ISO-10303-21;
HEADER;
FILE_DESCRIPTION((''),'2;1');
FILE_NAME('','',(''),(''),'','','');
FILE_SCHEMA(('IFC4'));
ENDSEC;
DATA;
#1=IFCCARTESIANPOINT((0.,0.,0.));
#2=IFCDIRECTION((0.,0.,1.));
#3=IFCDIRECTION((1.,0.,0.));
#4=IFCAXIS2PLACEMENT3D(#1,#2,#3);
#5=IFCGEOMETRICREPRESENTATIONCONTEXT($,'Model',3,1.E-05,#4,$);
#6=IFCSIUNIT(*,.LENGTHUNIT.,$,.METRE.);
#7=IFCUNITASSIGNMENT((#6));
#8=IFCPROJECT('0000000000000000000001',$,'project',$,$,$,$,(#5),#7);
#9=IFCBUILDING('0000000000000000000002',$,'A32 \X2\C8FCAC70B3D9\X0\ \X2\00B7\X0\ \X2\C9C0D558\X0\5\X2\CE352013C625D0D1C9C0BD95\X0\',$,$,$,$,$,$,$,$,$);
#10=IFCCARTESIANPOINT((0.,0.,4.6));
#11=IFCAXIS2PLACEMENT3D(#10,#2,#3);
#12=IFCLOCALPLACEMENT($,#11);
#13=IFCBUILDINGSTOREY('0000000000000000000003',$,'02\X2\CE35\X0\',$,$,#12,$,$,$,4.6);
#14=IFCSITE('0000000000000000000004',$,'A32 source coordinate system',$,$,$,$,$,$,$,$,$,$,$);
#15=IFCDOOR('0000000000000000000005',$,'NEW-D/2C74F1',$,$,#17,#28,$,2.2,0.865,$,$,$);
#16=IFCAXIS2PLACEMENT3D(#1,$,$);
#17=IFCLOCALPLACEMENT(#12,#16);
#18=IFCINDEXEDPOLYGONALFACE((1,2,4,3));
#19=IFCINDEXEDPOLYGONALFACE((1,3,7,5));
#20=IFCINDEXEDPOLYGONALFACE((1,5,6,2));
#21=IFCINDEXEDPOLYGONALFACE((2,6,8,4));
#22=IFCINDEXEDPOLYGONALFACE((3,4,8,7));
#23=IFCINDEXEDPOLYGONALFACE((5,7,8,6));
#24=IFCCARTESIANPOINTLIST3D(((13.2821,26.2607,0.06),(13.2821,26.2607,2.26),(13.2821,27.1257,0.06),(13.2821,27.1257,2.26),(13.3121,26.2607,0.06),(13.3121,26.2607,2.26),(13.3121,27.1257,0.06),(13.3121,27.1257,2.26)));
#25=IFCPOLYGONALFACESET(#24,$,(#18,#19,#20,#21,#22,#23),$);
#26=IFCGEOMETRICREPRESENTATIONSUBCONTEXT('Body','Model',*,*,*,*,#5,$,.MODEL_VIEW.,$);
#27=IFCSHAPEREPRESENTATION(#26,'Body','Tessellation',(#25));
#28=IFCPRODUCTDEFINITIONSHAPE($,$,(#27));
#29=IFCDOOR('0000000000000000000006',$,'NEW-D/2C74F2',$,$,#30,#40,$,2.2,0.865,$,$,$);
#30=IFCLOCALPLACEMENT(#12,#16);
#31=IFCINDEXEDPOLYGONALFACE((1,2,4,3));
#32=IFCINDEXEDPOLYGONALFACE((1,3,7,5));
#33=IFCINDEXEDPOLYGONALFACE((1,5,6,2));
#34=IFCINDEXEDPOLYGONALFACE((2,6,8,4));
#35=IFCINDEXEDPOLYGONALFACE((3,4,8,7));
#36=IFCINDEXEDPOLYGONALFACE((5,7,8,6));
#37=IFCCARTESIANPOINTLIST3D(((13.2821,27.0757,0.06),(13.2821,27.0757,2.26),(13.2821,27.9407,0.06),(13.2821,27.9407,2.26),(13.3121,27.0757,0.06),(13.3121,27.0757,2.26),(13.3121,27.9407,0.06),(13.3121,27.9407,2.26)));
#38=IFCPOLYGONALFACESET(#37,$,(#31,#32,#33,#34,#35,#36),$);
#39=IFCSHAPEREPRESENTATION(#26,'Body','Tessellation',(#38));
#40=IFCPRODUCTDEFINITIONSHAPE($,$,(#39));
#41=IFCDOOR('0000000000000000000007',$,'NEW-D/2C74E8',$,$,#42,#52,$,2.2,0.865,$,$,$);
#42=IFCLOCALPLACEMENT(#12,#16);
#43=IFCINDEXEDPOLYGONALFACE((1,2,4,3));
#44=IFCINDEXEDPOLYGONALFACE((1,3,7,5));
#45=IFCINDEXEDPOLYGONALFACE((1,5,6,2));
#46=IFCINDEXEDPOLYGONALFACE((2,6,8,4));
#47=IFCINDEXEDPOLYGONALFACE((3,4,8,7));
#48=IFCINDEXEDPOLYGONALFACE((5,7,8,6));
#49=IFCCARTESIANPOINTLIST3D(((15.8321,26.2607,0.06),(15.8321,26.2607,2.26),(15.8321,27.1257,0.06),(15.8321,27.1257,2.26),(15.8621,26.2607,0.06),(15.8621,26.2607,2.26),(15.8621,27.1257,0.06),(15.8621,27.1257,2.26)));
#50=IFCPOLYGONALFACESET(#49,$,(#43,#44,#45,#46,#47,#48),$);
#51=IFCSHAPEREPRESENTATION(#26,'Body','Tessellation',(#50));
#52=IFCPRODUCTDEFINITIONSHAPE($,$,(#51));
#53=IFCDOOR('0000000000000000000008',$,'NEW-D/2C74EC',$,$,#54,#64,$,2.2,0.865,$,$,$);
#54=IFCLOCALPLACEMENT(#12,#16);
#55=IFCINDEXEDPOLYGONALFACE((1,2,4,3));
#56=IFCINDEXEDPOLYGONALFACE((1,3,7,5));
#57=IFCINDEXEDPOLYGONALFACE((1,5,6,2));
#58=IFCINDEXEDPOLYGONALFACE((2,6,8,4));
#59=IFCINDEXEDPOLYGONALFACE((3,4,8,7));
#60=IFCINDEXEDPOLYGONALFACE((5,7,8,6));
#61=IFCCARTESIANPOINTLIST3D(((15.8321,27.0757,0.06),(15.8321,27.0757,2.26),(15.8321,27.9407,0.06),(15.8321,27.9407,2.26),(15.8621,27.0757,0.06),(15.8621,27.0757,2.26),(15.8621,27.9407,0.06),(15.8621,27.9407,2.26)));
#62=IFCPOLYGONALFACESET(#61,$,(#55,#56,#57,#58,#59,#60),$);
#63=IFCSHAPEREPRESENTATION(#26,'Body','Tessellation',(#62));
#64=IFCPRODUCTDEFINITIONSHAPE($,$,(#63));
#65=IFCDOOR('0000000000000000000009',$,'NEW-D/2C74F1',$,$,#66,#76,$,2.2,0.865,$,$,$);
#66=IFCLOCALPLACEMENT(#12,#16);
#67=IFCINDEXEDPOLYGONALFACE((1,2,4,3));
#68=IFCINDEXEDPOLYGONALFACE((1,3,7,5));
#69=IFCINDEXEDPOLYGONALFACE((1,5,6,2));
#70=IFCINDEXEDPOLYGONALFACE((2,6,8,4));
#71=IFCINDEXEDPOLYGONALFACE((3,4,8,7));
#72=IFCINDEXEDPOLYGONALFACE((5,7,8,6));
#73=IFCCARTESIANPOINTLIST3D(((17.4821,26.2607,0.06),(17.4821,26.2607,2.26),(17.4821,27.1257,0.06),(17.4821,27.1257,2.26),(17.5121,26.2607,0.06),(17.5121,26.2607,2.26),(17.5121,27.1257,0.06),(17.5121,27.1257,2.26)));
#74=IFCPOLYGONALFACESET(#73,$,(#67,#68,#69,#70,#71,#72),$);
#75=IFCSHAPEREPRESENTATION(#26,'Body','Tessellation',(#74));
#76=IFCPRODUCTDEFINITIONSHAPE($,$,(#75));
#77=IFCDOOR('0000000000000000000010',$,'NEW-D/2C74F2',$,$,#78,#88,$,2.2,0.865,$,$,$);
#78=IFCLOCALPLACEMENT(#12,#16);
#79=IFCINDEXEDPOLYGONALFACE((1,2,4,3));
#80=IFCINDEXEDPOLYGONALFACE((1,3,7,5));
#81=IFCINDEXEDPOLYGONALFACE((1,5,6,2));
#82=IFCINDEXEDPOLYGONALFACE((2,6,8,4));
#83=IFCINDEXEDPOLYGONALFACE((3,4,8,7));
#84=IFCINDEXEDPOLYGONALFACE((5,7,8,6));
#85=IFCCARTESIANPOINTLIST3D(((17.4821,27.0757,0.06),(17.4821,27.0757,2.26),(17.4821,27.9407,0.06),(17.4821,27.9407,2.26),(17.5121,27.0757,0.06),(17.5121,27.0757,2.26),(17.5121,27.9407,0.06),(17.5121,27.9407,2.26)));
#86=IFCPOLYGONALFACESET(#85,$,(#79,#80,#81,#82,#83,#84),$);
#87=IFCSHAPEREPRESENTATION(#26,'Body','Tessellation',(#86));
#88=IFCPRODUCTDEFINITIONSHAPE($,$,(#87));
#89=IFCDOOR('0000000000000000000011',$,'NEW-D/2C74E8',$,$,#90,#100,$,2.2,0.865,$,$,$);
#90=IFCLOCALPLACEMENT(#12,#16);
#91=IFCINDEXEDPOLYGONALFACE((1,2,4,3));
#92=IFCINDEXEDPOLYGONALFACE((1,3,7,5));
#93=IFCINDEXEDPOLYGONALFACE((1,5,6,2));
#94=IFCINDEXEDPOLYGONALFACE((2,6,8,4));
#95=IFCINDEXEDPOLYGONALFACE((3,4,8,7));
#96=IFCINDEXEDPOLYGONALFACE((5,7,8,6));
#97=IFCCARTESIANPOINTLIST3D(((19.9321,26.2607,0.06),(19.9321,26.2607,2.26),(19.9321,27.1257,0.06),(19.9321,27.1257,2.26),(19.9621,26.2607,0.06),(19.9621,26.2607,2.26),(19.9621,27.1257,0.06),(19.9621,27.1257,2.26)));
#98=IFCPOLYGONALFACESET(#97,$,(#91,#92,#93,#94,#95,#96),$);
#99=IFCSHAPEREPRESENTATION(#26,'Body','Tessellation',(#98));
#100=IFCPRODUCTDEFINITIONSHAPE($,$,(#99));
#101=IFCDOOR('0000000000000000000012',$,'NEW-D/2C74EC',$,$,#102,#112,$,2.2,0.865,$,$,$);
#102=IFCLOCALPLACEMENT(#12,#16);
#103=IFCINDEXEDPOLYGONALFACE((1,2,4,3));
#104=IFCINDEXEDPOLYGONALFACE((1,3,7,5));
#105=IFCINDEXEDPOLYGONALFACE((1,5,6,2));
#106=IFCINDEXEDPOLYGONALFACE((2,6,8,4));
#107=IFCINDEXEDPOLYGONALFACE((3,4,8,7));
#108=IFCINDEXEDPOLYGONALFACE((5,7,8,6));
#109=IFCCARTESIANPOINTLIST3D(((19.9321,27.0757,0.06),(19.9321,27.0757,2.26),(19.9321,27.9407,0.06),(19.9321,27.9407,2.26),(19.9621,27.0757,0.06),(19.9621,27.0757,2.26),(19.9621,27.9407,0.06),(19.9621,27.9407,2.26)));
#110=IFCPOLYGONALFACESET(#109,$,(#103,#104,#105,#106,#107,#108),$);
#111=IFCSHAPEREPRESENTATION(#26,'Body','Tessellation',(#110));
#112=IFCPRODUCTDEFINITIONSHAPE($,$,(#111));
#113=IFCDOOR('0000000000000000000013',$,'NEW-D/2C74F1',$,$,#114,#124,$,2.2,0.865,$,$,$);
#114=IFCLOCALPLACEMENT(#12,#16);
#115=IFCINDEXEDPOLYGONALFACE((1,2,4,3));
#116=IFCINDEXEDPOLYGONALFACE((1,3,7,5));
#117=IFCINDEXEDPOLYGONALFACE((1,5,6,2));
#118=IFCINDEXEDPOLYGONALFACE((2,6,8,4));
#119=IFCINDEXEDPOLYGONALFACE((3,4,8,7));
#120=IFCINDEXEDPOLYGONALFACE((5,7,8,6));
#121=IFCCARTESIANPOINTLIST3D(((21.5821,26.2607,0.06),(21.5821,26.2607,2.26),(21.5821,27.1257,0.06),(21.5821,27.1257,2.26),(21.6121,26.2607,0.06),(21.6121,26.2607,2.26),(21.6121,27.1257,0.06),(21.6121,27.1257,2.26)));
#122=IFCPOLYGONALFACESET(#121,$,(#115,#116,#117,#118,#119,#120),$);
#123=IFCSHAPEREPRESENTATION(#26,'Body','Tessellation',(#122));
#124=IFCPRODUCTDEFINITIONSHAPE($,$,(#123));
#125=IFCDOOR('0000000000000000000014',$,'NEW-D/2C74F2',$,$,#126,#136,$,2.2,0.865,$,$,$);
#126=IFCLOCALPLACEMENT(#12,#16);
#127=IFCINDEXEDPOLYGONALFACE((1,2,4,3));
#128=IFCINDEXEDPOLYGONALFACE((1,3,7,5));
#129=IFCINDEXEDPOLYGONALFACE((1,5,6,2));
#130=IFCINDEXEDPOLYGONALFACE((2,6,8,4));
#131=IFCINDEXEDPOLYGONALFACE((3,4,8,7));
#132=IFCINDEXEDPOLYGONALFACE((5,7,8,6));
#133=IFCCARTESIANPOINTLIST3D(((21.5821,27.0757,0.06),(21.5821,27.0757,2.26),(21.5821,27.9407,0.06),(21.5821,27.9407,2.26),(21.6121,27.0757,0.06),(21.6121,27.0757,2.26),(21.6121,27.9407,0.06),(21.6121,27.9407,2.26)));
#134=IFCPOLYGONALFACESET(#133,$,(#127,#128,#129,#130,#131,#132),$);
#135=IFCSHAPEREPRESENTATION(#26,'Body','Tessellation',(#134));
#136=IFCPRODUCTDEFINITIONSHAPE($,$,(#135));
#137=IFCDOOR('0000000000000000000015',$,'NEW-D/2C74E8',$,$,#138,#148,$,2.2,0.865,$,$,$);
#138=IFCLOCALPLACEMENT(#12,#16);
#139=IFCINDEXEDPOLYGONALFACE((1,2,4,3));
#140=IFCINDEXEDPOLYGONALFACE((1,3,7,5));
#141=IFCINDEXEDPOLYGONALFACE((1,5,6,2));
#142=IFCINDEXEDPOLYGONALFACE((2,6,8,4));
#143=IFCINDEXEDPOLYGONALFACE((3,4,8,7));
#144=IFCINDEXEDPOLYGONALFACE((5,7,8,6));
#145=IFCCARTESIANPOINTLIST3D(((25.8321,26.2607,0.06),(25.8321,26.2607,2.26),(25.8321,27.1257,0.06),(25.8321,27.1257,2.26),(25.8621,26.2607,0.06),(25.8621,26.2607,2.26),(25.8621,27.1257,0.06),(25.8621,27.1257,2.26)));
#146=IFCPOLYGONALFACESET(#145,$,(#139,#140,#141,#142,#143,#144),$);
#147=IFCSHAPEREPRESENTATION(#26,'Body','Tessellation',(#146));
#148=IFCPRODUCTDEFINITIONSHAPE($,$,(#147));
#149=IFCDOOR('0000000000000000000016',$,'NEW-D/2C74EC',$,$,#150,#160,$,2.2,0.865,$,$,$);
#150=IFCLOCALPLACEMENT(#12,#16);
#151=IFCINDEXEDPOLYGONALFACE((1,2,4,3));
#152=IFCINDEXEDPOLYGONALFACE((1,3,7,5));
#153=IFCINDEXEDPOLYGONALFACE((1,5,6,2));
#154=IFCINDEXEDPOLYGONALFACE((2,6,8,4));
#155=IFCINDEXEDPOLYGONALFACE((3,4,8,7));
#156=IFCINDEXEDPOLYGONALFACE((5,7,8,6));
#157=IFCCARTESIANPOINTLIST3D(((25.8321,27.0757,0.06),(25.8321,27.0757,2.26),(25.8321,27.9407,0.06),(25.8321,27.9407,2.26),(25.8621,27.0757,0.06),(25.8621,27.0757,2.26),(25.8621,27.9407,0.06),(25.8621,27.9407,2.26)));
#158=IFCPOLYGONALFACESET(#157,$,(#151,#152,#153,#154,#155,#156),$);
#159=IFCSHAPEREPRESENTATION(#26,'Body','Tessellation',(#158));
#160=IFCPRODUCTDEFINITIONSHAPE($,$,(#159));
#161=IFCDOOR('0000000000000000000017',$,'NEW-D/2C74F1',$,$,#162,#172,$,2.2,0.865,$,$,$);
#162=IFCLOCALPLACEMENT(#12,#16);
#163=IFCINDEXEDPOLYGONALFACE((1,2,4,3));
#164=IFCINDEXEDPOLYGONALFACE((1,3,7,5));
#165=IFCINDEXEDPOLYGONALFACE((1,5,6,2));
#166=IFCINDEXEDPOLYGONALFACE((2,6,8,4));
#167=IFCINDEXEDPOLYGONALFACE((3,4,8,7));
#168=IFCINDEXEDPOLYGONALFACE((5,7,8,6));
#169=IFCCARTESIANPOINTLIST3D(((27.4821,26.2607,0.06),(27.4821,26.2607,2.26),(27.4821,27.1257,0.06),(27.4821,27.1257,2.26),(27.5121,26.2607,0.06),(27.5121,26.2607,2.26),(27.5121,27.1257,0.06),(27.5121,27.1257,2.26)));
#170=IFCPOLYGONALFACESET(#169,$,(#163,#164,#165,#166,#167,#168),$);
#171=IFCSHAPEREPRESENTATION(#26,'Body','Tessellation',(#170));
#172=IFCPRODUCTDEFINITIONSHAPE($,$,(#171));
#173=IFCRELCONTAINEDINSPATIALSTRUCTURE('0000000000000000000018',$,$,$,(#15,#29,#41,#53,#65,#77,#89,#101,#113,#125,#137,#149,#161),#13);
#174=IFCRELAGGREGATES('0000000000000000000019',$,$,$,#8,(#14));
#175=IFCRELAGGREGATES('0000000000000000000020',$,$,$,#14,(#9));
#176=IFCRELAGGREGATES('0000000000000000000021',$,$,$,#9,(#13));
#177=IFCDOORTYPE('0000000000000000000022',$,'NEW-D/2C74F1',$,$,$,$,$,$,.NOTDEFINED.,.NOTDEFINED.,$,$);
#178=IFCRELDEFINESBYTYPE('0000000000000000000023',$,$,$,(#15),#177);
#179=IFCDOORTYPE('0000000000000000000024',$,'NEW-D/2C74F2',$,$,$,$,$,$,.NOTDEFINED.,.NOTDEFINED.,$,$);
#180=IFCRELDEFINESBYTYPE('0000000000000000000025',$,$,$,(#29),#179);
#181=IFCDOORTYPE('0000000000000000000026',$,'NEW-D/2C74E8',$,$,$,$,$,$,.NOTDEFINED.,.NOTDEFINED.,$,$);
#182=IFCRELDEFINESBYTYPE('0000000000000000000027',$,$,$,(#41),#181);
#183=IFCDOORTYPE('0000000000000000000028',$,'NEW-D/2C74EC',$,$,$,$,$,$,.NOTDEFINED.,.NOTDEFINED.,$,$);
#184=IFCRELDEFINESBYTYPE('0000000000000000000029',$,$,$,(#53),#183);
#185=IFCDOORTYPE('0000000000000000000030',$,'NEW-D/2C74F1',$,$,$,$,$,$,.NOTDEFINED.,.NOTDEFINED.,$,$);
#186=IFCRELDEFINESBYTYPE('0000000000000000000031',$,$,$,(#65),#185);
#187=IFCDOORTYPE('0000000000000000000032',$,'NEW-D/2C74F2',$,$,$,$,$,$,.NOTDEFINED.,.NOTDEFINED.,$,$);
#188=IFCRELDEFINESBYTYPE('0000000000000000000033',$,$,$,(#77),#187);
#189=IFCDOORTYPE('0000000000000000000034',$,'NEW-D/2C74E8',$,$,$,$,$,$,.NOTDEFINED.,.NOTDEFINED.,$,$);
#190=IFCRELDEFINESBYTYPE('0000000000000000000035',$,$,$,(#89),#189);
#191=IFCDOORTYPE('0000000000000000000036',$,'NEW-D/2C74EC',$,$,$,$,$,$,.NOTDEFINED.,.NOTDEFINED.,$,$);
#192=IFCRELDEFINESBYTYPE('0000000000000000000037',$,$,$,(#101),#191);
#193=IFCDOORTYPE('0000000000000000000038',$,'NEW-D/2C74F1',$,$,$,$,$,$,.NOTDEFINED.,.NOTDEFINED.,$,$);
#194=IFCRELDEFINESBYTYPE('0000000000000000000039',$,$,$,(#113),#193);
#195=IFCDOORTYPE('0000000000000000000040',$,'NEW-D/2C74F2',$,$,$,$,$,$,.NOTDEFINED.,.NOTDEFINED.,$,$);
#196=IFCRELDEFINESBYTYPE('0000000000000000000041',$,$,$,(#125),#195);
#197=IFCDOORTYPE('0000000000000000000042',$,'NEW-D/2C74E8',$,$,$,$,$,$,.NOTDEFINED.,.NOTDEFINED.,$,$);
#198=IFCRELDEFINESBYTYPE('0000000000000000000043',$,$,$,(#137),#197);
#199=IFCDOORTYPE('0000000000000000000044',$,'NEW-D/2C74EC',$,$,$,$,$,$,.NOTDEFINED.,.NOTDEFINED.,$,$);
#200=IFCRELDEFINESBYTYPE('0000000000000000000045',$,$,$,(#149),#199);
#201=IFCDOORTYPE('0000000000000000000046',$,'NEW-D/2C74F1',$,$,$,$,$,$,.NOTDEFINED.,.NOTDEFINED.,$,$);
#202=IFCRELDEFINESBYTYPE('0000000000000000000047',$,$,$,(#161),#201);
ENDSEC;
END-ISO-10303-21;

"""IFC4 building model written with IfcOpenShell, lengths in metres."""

from ifc_helpers import new_model, si_unit, frame, origin, origin_with_axes, place, context, subcontext, project, spatial, polyline, outline, extrude, source, transform, mapped, type_object, type_shapes, element, save


model = new_model("IFC4")

# Units and contexts
model_context = context("Model", 3, precision=1e-05, world=origin_with_axes())
body_context = subcontext(model_context, "Body", "Model", "MODEL_VIEW")
ifc_project = project(units=[si_unit("LENGTHUNIT", "METRE")], contexts=[model_context])

# Site, building, storey
site = spatial("IfcSite", under=ifc_project, Name="A32 source coordinate system")
building = spatial("IfcBuilding", under=site, Name="A32 주거동 · 지하5층–옥탑지붕")
storey_placement = place(None, frame((0.0, 0.0, 4.6), z_axis=(0.0, 0.0, 1.0), x_axis=(1.0, 0.0, 0.0)))
storey = spatial("IfcBuildingStorey", under=building, at=storey_placement, Name="02층", Elevation=4.6)

# Doors
door_type_1 = type_object("IfcDoorType", Name="NEW-D/2C74F1", OperationType="NOTDEFINED", PredefinedType="NOTDEFINED")
shared_shape_1 = source(origin(), body_context, "Body", "SweptSolid", [
    extrude(outline(polyline([(13.3121, 26.2607), (13.2821, 26.2607), (13.2821, 27.1257), (13.3121, 27.1257), (13.3121, 26.2607)])), frame((0.0, 0.0, 0.06)), (0.0, 0.0, 1.0), 2.2),
])
type_shapes(door_type_1, [shared_shape_1])
door_1_placement = place(storey_placement, origin_with_axes())
element("IfcDoor", 1, at=door_1_placement, inside=storey, type_object=door_type_1, Name="NEW-D/2C74F1", OverallHeight=2.2, OverallWidth=0.865, context=body_context, shape_type="MappedRepresentation", body=[
    mapped(shared_shape_1, transform((0.0, 0.0, 0.0), scale=1.0)),
])
door_type_2 = type_object("IfcDoorType", Name="NEW-D/2C74F2", OperationType="NOTDEFINED", PredefinedType="NOTDEFINED")
shared_shape_2 = source(origin(), body_context, "Body", "SweptSolid", [
    extrude(outline(polyline([(13.2821, 27.0757), (13.2821, 27.9407), (13.3121, 27.9407), (13.3121, 27.0757), (13.2821, 27.0757)])), frame((0.0, 0.0, 0.06)), (0.0, 0.0, 1.0), 2.2),
])
type_shapes(door_type_2, [shared_shape_2])
door_2_placement = place(storey_placement, origin_with_axes())
element("IfcDoor", 2, at=door_2_placement, inside=storey, type_object=door_type_2, Name="NEW-D/2C74F2", OverallHeight=2.2, OverallWidth=0.865, context=body_context, shape_type="MappedRepresentation", body=[
    mapped(shared_shape_2, transform((0.0, 0.0, 0.0), scale=1.0)),
])
door_type_3 = type_object("IfcDoorType", Name="NEW-D/2C74E8", OperationType="NOTDEFINED", PredefinedType="NOTDEFINED")
shared_shape_3 = source(origin(), body_context, "Body", "SweptSolid", [
    extrude(outline(polyline([(15.8621, 27.1257), (15.8621, 26.2607), (15.8321, 26.2607), (15.8321, 27.1257), (15.8621, 27.1257)])), frame((0.0, 0.0, 0.06)), (0.0, 0.0, 1.0), 2.2),
])
type_shapes(door_type_3, [shared_shape_3])
door_3_placement = place(storey_placement, origin_with_axes())
element("IfcDoor", 3, at=door_3_placement, inside=storey, type_object=door_type_3, Name="NEW-D/2C74E8", OverallHeight=2.2, OverallWidth=0.865, context=body_context, shape_type="MappedRepresentation", body=[
    mapped(shared_shape_3, transform((0.0, 0.0, 0.0), scale=1.0)),
])
door_type_4 = type_object("IfcDoorType", Name="NEW-D/2C74EC", OperationType="NOTDEFINED", PredefinedType="NOTDEFINED")
shared_shape_4 = source(origin(), body_context, "Body", "SweptSolid", [
    extrude(outline(polyline([(15.8321, 27.9407), (15.8621, 27.9407), (15.8621, 27.0757), (15.8321, 27.0757), (15.8321, 27.9407)])), frame((0.0, 0.0, 0.06)), (0.0, 0.0, 1.0), 2.2),
])
type_shapes(door_type_4, [shared_shape_4])
door_4_placement = place(storey_placement, origin_with_axes())
element("IfcDoor", 4, at=door_4_placement, inside=storey, type_object=door_type_4, Name="NEW-D/2C74EC", OverallHeight=2.2, OverallWidth=0.865, context=body_context, shape_type="MappedRepresentation", body=[
    mapped(shared_shape_4, transform((0.0, 0.0, 0.0), scale=1.0)),
])
door_type_5 = type_object("IfcDoorType", Name="NEW-D/2C74F1", OperationType="NOTDEFINED", PredefinedType="NOTDEFINED")
shared_shape_5 = source(origin(), body_context, "Body", "SweptSolid", [
    extrude(outline(polyline([(17.5121, 26.2607), (17.4821, 26.2607), (17.4821, 27.1257), (17.5121, 27.1257), (17.5121, 26.2607)])), frame((0.0, 0.0, 0.06)), (0.0, 0.0, 1.0), 2.2),
])
type_shapes(door_type_5, [shared_shape_5])
door_5_placement = place(storey_placement, origin_with_axes())
element("IfcDoor", 5, at=door_5_placement, inside=storey, type_object=door_type_5, Name="NEW-D/2C74F1", OverallHeight=2.2, OverallWidth=0.865, context=body_context, shape_type="MappedRepresentation", body=[
    mapped(shared_shape_5, transform((0.0, 0.0, 0.0), scale=1.0)),
])
door_type_6 = type_object("IfcDoorType", Name="NEW-D/2C74F2", OperationType="NOTDEFINED", PredefinedType="NOTDEFINED")
shared_shape_6 = source(origin(), body_context, "Body", "SweptSolid", [
    extrude(outline(polyline([(17.4821, 27.0757), (17.4821, 27.9407), (17.5121, 27.9407), (17.5121, 27.0757), (17.4821, 27.0757)])), frame((0.0, 0.0, 0.06)), (0.0, 0.0, 1.0), 2.2),
])
type_shapes(door_type_6, [shared_shape_6])
door_6_placement = place(storey_placement, origin_with_axes())
element("IfcDoor", 6, at=door_6_placement, inside=storey, type_object=door_type_6, Name="NEW-D/2C74F2", OverallHeight=2.2, OverallWidth=0.865, context=body_context, shape_type="MappedRepresentation", body=[
    mapped(shared_shape_6, transform((0.0, 0.0, 0.0), scale=1.0)),
])
door_type_7 = type_object("IfcDoorType", Name="NEW-D/2C74E8", OperationType="NOTDEFINED", PredefinedType="NOTDEFINED")
shared_shape_7 = source(origin(), body_context, "Body", "SweptSolid", [
    extrude(outline(polyline([(19.9621, 27.1257), (19.9621, 26.2607), (19.9321, 26.2607), (19.9321, 27.1257), (19.9621, 27.1257)])), frame((0.0, 0.0, 0.06)), (0.0, 0.0, 1.0), 2.2),
])
type_shapes(door_type_7, [shared_shape_7])
door_7_placement = place(storey_placement, origin_with_axes())
element("IfcDoor", 7, at=door_7_placement, inside=storey, type_object=door_type_7, Name="NEW-D/2C74E8", OverallHeight=2.2, OverallWidth=0.865, context=body_context, shape_type="MappedRepresentation", body=[
    mapped(shared_shape_7, transform((0.0, 0.0, 0.0), scale=1.0)),
])
door_type_8 = type_object("IfcDoorType", Name="NEW-D/2C74EC", OperationType="NOTDEFINED", PredefinedType="NOTDEFINED")
shared_shape_8 = source(origin(), body_context, "Body", "SweptSolid", [
    extrude(outline(polyline([(19.9321, 27.9407), (19.9621, 27.9407), (19.9621, 27.0757), (19.9321, 27.0757), (19.9321, 27.9407)])), frame((0.0, 0.0, 0.06)), (0.0, 0.0, 1.0), 2.2),
])
type_shapes(door_type_8, [shared_shape_8])
door_8_placement = place(storey_placement, origin_with_axes())
element("IfcDoor", 8, at=door_8_placement, inside=storey, type_object=door_type_8, Name="NEW-D/2C74EC", OverallHeight=2.2, OverallWidth=0.865, context=body_context, shape_type="MappedRepresentation", body=[
    mapped(shared_shape_8, transform((0.0, 0.0, 0.0), scale=1.0)),
])
door_type_9 = type_object("IfcDoorType", Name="NEW-D/2C74F1", OperationType="NOTDEFINED", PredefinedType="NOTDEFINED")
shared_shape_9 = source(origin(), body_context, "Body", "SweptSolid", [
    extrude(outline(polyline([(21.6121, 26.2607), (21.5821, 26.2607), (21.5821, 27.1257), (21.6121, 27.1257), (21.6121, 26.2607)])), frame((0.0, 0.0, 0.06)), (0.0, 0.0, 1.0), 2.2),
])
type_shapes(door_type_9, [shared_shape_9])
door_9_placement = place(storey_placement, origin_with_axes())
element("IfcDoor", 9, at=door_9_placement, inside=storey, type_object=door_type_9, Name="NEW-D/2C74F1", OverallHeight=2.2, OverallWidth=0.865, context=body_context, shape_type="MappedRepresentation", body=[
    mapped(shared_shape_9, transform((0.0, 0.0, 0.0), scale=1.0)),
])
door_type_10 = type_object("IfcDoorType", Name="NEW-D/2C74F2", OperationType="NOTDEFINED", PredefinedType="NOTDEFINED")
shared_shape_10 = source(origin(), body_context, "Body", "SweptSolid", [
    extrude(outline(polyline([(21.5821, 27.0757), (21.5821, 27.9407), (21.6121, 27.9407), (21.6121, 27.0757), (21.5821, 27.0757)])), frame((0.0, 0.0, 0.06)), (0.0, 0.0, 1.0), 2.2),
])
type_shapes(door_type_10, [shared_shape_10])
door_10_placement = place(storey_placement, origin_with_axes())
element("IfcDoor", 10, at=door_10_placement, inside=storey, type_object=door_type_10, Name="NEW-D/2C74F2", OverallHeight=2.2, OverallWidth=0.865, context=body_context, shape_type="MappedRepresentation", body=[
    mapped(shared_shape_10, transform((0.0, 0.0, 0.0), scale=1.0)),
])
door_type_11 = type_object("IfcDoorType", Name="NEW-D/2C74E8", OperationType="NOTDEFINED", PredefinedType="NOTDEFINED")
shared_shape_11 = source(origin(), body_context, "Body", "SweptSolid", [
    extrude(outline(polyline([(25.8621, 27.1257), (25.8621, 26.2607), (25.8321, 26.2607), (25.8321, 27.1257), (25.8621, 27.1257)])), frame((0.0, 0.0, 0.06)), (0.0, 0.0, 1.0), 2.2),
])
type_shapes(door_type_11, [shared_shape_11])
door_11_placement = place(storey_placement, origin_with_axes())
element("IfcDoor", 11, at=door_11_placement, inside=storey, type_object=door_type_11, Name="NEW-D/2C74E8", OverallHeight=2.2, OverallWidth=0.865, context=body_context, shape_type="MappedRepresentation", body=[
    mapped(shared_shape_11, transform((0.0, 0.0, 0.0), scale=1.0)),
])
door_type_12 = type_object("IfcDoorType", Name="NEW-D/2C74EC", OperationType="NOTDEFINED", PredefinedType="NOTDEFINED")
shared_shape_12 = source(origin(), body_context, "Body", "SweptSolid", [
    extrude(outline(polyline([(25.8321, 27.9407), (25.8621, 27.9407), (25.8621, 27.0757), (25.8321, 27.0757), (25.8321, 27.9407)])), frame((0.0, 0.0, 0.06)), (0.0, 0.0, 1.0), 2.2),
])
type_shapes(door_type_12, [shared_shape_12])
door_12_placement = place(storey_placement, origin_with_axes())
element("IfcDoor", 12, at=door_12_placement, inside=storey, type_object=door_type_12, Name="NEW-D/2C74EC", OverallHeight=2.2, OverallWidth=0.865, context=body_context, shape_type="MappedRepresentation", body=[
    mapped(shared_shape_12, transform((0.0, 0.0, 0.0), scale=1.0)),
])
door_type_13 = type_object("IfcDoorType", Name="NEW-D/2C74F1", OperationType="NOTDEFINED", PredefinedType="NOTDEFINED")
shared_shape_13 = source(origin(), body_context, "Body", "SweptSolid", [
    extrude(outline(polyline([(27.5121, 26.2607), (27.4821, 26.2607), (27.4821, 27.1257), (27.5121, 27.1257), (27.5121, 26.2607)])), frame((0.0, 0.0, 0.06)), (0.0, 0.0, 1.0), 2.2),
])
type_shapes(door_type_13, [shared_shape_13])
door_13_placement = place(storey_placement, origin_with_axes())
element("IfcDoor", 13, at=door_13_placement, inside=storey, type_object=door_type_13, Name="NEW-D/2C74F1", OverallHeight=2.2, OverallWidth=0.865, context=body_context, shape_type="MappedRepresentation", body=[
    mapped(shared_shape_13, transform((0.0, 0.0, 0.0), scale=1.0)),
])

save(model, "model.ifc")
